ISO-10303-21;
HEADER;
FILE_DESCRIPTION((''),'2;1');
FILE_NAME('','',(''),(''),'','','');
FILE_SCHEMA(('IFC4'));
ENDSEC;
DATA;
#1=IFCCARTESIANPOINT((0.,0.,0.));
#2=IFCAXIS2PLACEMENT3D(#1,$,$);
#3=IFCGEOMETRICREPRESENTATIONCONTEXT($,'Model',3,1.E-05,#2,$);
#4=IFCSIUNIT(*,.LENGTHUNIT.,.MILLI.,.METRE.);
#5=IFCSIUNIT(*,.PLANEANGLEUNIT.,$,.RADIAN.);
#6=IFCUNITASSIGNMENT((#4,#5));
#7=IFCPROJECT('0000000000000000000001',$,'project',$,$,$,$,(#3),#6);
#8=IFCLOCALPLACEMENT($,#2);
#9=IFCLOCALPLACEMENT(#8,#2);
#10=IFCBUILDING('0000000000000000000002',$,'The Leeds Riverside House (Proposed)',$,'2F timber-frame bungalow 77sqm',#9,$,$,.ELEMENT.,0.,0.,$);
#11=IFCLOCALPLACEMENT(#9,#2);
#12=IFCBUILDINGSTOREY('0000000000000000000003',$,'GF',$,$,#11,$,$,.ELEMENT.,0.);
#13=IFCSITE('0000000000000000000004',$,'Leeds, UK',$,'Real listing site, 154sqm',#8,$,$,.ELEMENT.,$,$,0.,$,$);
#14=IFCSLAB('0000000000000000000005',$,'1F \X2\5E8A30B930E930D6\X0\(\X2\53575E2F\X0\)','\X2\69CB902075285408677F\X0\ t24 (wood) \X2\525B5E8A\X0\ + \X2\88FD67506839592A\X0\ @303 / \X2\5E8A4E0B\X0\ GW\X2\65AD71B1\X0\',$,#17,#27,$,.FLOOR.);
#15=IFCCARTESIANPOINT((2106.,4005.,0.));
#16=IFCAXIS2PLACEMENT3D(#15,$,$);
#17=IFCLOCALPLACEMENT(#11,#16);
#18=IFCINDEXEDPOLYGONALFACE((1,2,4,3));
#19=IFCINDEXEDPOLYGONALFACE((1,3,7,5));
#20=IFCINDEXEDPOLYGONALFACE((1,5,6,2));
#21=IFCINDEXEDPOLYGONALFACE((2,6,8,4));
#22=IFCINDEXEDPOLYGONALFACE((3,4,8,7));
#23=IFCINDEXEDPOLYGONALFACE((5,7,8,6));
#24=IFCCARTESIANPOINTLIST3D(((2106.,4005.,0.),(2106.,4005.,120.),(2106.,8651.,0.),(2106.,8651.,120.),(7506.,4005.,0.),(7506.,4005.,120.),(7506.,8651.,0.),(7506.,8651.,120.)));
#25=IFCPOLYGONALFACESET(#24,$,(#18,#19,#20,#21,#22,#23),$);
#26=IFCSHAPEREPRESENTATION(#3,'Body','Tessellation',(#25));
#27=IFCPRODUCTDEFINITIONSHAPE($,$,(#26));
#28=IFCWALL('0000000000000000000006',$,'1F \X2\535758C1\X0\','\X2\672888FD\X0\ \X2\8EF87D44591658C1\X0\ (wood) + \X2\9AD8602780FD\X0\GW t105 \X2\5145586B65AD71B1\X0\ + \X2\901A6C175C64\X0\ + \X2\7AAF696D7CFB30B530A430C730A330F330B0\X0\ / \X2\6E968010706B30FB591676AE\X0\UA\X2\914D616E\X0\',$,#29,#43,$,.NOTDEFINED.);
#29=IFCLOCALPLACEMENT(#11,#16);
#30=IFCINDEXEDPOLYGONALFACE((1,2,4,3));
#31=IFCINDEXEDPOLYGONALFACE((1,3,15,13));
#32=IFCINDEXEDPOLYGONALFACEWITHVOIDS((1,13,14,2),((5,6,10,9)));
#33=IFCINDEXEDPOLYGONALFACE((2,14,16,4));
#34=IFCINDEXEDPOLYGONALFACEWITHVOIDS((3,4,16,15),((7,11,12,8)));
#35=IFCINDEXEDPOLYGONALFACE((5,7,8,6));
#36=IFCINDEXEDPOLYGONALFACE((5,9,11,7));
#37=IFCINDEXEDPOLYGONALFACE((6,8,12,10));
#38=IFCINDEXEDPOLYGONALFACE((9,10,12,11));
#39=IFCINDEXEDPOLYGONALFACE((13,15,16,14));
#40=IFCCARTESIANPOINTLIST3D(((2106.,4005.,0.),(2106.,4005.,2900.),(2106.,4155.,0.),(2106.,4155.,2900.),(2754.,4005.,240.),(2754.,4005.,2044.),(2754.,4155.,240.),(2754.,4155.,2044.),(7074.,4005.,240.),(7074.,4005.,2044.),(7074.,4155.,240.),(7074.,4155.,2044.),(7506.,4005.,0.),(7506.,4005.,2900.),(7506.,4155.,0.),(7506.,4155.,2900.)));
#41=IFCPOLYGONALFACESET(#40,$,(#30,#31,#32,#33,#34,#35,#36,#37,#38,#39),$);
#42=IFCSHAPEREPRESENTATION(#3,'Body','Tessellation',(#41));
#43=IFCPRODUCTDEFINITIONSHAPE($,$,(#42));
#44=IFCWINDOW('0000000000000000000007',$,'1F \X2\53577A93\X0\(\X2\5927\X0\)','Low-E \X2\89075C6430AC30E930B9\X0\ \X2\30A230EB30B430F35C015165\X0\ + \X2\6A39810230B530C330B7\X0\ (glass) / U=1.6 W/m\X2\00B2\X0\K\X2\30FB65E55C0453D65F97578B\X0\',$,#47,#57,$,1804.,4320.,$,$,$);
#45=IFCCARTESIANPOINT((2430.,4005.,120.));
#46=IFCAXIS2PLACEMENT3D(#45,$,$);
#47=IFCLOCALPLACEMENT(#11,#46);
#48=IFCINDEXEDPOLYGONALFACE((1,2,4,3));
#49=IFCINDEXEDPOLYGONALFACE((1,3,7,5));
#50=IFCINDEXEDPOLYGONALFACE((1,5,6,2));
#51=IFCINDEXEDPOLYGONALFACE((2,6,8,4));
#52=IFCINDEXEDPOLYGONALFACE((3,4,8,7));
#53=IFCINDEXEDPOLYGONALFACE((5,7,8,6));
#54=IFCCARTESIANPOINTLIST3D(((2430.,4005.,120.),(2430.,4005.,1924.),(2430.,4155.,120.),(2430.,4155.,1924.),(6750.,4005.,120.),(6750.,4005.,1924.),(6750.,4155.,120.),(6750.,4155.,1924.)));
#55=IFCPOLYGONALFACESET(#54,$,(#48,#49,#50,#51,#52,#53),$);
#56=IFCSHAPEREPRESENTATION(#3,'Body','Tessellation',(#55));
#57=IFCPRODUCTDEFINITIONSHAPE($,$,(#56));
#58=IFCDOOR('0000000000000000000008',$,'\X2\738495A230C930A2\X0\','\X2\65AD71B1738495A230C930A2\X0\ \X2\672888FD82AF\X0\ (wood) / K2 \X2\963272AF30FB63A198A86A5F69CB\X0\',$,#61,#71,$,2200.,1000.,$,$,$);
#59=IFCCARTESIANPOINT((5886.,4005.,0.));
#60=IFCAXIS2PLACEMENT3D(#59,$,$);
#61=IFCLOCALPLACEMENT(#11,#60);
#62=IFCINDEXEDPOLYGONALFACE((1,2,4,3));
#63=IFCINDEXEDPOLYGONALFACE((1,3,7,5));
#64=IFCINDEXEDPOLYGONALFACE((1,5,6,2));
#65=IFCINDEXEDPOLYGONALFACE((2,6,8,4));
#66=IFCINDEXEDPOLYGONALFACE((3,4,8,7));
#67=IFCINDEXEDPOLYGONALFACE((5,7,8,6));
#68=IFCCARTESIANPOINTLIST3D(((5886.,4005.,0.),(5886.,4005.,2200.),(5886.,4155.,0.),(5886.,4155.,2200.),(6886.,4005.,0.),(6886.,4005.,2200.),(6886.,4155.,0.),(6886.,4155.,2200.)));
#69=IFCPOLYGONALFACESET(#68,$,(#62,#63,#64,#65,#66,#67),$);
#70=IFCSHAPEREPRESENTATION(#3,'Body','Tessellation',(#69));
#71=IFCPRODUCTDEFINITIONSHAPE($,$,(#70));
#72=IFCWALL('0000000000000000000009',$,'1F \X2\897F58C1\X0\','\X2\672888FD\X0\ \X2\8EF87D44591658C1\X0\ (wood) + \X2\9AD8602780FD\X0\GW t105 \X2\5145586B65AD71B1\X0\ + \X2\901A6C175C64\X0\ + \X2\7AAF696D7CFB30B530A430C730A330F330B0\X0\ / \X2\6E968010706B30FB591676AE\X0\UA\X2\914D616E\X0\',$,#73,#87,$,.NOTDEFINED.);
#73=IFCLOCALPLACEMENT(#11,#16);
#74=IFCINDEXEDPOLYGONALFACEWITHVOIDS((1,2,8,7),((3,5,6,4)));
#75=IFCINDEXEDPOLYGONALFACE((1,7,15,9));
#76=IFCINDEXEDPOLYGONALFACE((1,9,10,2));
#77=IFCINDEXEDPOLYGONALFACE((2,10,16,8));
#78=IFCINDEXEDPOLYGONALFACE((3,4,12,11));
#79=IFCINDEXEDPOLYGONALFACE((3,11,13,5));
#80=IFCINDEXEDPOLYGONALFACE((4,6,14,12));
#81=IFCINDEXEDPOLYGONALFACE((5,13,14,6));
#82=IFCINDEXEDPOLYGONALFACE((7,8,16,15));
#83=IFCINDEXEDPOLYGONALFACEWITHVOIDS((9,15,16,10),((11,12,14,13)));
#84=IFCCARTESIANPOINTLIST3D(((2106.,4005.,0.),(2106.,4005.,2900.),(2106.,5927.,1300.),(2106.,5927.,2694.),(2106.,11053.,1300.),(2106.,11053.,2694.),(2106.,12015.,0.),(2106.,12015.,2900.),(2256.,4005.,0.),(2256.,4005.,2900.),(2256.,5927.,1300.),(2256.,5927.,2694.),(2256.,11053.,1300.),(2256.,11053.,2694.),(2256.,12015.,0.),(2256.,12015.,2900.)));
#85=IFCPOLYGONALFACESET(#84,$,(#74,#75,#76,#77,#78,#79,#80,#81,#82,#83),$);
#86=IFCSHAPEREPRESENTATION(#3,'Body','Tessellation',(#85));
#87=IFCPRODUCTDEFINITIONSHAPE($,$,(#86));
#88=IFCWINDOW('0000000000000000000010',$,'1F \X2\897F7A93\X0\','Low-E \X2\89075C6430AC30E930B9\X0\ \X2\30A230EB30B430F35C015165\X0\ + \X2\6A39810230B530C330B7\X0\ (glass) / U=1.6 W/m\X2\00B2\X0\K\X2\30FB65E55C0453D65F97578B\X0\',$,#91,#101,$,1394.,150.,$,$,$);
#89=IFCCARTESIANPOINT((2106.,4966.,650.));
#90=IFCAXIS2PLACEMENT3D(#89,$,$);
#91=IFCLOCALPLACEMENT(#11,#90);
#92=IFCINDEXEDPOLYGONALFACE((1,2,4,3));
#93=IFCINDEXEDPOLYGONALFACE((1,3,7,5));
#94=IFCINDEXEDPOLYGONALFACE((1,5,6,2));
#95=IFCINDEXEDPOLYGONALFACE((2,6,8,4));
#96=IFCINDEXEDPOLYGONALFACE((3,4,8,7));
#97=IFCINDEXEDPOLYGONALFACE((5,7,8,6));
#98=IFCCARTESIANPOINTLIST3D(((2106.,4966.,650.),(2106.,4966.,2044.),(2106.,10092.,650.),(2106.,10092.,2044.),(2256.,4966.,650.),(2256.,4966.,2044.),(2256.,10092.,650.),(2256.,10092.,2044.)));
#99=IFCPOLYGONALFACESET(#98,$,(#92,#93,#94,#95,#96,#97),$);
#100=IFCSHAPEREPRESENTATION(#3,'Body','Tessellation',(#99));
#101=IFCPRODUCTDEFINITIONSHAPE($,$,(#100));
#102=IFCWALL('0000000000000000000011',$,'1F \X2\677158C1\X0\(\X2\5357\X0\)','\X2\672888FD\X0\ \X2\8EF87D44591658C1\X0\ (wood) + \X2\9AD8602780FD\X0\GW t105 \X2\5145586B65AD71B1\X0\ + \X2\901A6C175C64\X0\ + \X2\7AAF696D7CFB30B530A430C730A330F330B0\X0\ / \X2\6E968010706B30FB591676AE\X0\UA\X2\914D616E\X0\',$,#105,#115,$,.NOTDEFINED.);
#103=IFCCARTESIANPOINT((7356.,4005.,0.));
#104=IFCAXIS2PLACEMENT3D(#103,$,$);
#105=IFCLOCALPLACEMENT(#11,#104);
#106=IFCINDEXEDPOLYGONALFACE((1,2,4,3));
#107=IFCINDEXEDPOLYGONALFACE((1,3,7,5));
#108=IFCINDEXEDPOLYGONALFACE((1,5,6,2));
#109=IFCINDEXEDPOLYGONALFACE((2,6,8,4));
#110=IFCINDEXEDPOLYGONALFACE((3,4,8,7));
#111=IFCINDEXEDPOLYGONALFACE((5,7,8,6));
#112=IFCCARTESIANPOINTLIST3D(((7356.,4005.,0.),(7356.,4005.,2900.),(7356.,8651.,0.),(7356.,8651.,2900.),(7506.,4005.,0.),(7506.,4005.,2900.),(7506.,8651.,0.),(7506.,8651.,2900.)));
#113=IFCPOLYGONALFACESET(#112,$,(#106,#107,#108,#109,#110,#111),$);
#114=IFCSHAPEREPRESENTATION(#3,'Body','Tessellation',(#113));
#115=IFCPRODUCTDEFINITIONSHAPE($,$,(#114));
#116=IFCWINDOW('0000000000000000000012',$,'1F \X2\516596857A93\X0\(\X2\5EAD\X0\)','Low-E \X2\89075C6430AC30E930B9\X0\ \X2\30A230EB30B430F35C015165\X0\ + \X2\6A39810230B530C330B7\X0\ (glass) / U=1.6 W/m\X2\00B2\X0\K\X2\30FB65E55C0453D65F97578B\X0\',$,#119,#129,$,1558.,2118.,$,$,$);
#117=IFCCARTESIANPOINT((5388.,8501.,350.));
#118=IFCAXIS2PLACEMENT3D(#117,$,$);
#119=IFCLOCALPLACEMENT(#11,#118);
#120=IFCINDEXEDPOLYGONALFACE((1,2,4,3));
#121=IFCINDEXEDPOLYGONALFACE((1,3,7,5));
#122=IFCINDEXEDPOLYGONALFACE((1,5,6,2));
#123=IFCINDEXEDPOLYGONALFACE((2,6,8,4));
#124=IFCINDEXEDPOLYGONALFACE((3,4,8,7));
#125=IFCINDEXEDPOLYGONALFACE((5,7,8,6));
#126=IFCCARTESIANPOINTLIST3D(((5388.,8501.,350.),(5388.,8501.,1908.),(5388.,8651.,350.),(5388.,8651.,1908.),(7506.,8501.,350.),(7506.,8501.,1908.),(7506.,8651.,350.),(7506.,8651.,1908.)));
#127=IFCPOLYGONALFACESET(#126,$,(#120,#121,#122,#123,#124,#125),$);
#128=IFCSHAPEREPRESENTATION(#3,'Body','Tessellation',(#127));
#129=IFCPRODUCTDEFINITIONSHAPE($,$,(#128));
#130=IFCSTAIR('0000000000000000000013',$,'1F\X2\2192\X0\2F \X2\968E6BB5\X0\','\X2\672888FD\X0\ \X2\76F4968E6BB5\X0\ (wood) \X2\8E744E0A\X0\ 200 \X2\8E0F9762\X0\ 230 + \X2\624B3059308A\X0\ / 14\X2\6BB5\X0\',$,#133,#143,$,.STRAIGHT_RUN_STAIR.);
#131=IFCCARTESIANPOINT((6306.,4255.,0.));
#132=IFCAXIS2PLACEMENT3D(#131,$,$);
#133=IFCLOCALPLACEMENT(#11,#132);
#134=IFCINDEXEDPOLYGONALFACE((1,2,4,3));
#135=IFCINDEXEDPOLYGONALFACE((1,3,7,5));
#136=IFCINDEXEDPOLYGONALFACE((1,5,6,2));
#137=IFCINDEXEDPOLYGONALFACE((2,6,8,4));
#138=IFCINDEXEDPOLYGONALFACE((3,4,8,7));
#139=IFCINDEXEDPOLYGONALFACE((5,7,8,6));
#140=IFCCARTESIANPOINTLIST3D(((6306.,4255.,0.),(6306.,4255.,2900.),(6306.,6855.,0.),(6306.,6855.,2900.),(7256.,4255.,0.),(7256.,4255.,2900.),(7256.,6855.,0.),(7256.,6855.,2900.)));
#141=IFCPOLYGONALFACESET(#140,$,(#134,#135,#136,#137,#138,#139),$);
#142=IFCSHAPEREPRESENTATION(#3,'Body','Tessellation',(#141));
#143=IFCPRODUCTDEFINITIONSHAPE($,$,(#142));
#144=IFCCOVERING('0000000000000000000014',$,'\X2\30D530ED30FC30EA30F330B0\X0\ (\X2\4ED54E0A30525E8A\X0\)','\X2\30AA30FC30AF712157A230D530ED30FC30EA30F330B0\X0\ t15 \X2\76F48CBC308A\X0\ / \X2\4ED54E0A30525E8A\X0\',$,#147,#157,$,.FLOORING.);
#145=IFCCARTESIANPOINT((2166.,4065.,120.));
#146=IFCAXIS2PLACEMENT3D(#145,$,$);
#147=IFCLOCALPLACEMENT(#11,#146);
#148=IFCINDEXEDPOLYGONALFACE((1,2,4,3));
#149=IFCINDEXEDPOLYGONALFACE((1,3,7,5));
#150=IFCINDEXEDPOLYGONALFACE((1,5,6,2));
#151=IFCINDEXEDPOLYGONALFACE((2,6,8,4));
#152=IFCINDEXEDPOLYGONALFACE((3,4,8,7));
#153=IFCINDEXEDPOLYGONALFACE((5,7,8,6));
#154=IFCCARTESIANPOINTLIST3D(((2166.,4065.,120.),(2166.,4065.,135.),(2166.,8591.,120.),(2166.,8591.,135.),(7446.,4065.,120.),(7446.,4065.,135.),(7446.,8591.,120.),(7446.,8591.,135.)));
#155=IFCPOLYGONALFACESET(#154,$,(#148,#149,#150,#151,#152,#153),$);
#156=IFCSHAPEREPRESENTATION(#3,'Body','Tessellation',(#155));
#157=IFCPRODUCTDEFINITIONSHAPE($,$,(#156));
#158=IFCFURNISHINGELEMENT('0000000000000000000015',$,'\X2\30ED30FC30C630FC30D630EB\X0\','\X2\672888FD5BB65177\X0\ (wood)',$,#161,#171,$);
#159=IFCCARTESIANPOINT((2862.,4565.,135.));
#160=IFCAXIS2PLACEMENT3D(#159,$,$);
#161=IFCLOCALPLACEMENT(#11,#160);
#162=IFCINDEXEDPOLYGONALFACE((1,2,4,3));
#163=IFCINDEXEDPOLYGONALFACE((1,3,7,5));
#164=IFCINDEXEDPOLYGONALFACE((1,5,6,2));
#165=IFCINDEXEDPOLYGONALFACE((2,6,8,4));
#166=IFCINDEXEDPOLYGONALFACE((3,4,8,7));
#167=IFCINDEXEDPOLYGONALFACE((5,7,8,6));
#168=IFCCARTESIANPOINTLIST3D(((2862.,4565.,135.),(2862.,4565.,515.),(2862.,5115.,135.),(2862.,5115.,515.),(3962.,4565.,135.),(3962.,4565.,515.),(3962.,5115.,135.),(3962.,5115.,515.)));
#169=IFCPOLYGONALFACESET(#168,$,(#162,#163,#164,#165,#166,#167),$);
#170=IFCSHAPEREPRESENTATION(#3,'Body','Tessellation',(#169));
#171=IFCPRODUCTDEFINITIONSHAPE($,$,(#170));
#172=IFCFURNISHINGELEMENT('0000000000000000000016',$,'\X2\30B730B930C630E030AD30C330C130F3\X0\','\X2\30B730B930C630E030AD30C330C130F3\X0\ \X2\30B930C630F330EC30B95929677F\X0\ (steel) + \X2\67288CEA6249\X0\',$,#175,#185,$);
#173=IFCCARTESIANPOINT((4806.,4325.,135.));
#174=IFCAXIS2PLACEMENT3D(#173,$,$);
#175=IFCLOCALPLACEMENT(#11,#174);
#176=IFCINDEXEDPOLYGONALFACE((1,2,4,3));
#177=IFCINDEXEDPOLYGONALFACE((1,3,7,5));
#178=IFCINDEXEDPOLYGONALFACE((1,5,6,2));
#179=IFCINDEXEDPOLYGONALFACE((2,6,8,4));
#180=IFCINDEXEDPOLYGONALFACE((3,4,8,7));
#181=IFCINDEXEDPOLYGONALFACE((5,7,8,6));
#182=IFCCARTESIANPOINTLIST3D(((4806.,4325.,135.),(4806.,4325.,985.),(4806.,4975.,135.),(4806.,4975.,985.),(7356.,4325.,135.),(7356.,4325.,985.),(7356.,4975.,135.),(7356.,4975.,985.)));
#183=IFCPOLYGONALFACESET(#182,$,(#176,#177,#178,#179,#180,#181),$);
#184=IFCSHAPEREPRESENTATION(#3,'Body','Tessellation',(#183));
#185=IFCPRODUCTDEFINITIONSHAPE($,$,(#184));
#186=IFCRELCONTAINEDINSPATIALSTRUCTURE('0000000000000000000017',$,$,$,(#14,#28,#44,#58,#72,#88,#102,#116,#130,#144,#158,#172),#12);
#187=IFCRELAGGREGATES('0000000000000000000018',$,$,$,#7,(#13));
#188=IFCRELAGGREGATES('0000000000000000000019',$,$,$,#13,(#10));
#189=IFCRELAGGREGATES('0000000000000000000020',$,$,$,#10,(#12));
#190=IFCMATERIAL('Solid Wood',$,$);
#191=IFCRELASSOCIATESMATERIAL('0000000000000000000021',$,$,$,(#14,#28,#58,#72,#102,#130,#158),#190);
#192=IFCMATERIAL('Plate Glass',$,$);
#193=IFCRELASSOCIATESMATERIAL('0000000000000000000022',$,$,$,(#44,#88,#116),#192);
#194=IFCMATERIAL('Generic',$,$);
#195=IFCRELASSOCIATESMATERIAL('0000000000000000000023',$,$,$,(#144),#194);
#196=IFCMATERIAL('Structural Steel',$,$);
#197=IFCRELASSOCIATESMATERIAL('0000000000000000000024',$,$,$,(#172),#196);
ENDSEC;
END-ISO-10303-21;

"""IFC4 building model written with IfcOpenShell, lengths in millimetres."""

from ifc_helpers import new_model, si_unit, frame, frame_2d, origin, place, context, project, spatial, rectangle, extrude, material, element, fill, save


model = new_model("IFC4")

# Units and contexts
model_context = context("Model", 3, precision=1e-05, world=origin())
ifc_project = project(units=[si_unit("LENGTHUNIT", "METRE", prefix="MILLI"), si_unit("PLANEANGLEUNIT", "RADIAN")], contexts=[model_context])

# Site, building, storey
site_placement = place(None, origin())
site = spatial("IfcSite", under=ifc_project, at=site_placement, Name="Leeds, UK", ObjectType="Real listing site, 154sqm", CompositionType="ELEMENT", RefElevation=0.0)
building_placement = place(site_placement, origin())
building = spatial("IfcBuilding", under=site, at=building_placement, Name="The Leeds Riverside House (Proposed)", ObjectType="2F timber-frame bungalow 77sqm", CompositionType="ELEMENT", ElevationOfRefHeight=0.0, ElevationOfTerrain=0.0)
storey_placement = place(building_placement, origin())
storey = spatial("IfcBuildingStorey", under=building, at=storey_placement, Name="GF", CompositionType="ELEMENT", Elevation=0.0)

# Slab
ifc_material_1 = material(Name="Solid Wood")
slab_1_placement = place(storey_placement, frame((2106.0, 4005.0, 0.0)))
element("IfcSlab", 1, at=slab_1_placement, inside=storey, material=ifc_material_1, Name="1F 床スラブ(南帯)", Description="構造用合板 t24 (wood) 剛床 + 製材根太 @303 / 床下 GW断熱", PredefinedType="FLOOR", context=model_context, shape_type="SweptSolid", body=[
    extrude(rectangle(XDim=5400.0, YDim=4646.0, at=frame_2d((2700.0, 2323.0))), frame((2106.0, 4005.0, 0.0)), (0.0, 0.0, 1.0), 120.0),
])

# Wall, openings, window, door
wall_1_placement = place(storey_placement, frame((2106.0, 4005.0, 0.0)))
wall_1 = element("IfcWall", 2, at=wall_1_placement, inside=storey, material=ifc_material_1, Name="1F 南壁", Description="木製 軸組外壁 (wood) + 高性能GW t105 充填断熱 + 通気層 + 窯業系サイディング / 準耐火・外皮UA配慮", PredefinedType="NOTDEFINED", context=model_context, shape_type="SweptSolid", body=[
    extrude(rectangle(XDim=5400.0, YDim=150.0, at=frame_2d((2700.0, 75.0))), frame((2106.0, 4005.0, 0.0)), (0.0, 0.0, 1.0), 2900.0),
])
opening_1_placement = place(storey_placement, frame((2430.0, 4005.0, 120.0)))
opening_1 = element("IfcOpeningElement", 3, at=opening_1_placement, cuts=wall_1, PredefinedType="NOTDEFINED", context=model_context, shape_type="SweptSolid", body=[
    extrude(rectangle(XDim=4320.0, YDim=150.0, at=frame_2d((2160.0, 75.0))), frame((2430.0, 4005.0, 120.0)), (0.0, 0.0, 1.0), 1804.0),
])
opening_2_placement = place(storey_placement, frame((5886.0, 4005.0, 0.0)))
opening_2 = element("IfcOpeningElement", 4, at=opening_2_placement, cuts=wall_1, PredefinedType="NOTDEFINED", context=model_context, shape_type="SweptSolid", body=[
    extrude(rectangle(XDim=1000.0, YDim=150.0, at=frame_2d((500.0, 75.0))), frame((5886.0, 4005.0, 0.0)), (0.0, 0.0, 1.0), 2200.0),
])
ifc_material_2 = material(Name="Plate Glass")
window_1_placement = place(storey_placement, frame((2430.0, 4005.0, 120.0)))
window_1 = element("IfcWindow", 5, at=window_1_placement, inside=storey, material=ifc_material_2, Name="1F 南窓(大)", Description="Low-E 複層ガラス アルゴン封入 + 樹脂サッシ (glass) / U=1.6 W/m²K・日射取得型", OverallHeight=1804.0, OverallWidth=4320.0, context=model_context, shape_type="SweptSolid", body=[
    extrude(rectangle(XDim=4320.0, YDim=150.0, at=frame_2d((2160.0, 75.0))), frame((2430.0, 4005.0, 120.0)), (0.0, 0.0, 1.0), 1804.0),
])
fill(opening_1, window_1)
door_1_placement = place(storey_placement, frame((5886.0, 4005.0, 0.0)))
door_1 = element("IfcDoor", 6, at=door_1_placement, inside=storey, material=ifc_material_1, Name="玄関ドア", Description="断熱玄関ドア 木製芯 (wood) / K2 防犯・採風機構", OverallHeight=2200.0, OverallWidth=1000.0, context=model_context, shape_type="SweptSolid", body=[
    extrude(rectangle(XDim=1000.0, YDim=150.0, at=frame_2d((500.0, 75.0))), frame((5886.0, 4005.0, 0.0)), (0.0, 0.0, 1.0), 2200.0),
])
fill(opening_2, door_1)

# Walls, openings, windows
wall_2_placement = place(storey_placement, frame((2106.0, 4005.0, 0.0)))
wall_2 = element("IfcWall", 7, at=wall_2_placement, inside=storey, material=ifc_material_1, Name="1F 西壁", Description="木製 軸組外壁 (wood) + 高性能GW t105 充填断熱 + 通気層 + 窯業系サイディング / 準耐火・外皮UA配慮", PredefinedType="NOTDEFINED", context=model_context, shape_type="SweptSolid", body=[
    extrude(rectangle(XDim=150.0, YDim=8010.0, at=frame_2d((75.0, 4005.0))), frame((2106.0, 4005.0, 0.0)), (0.0, 0.0, 1.0), 2900.0),
])
opening_3_placement = place(storey_placement, frame((2106.0, 4966.0, 650.0)))
opening_3 = element("IfcOpeningElement", 8, at=opening_3_placement, cuts=wall_2, PredefinedType="NOTDEFINED", context=model_context, shape_type="SweptSolid", body=[
    extrude(rectangle(XDim=150.0, YDim=5126.0, at=frame_2d((75.0, 2563.0))), frame((2106.0, 4966.0, 650.0)), (0.0, 0.0, 1.0), 1394.0),
])
window_2_placement = place(storey_placement, frame((2106.0, 4966.0, 650.0)))
window_2 = element("IfcWindow", 9, at=window_2_placement, inside=storey, material=ifc_material_2, Name="1F 西窓", Description="Low-E 複層ガラス アルゴン封入 + 樹脂サッシ (glass) / U=1.6 W/m²K・日射取得型", OverallHeight=1394.0, OverallWidth=150.0, context=model_context, shape_type="SweptSolid", body=[
    extrude(rectangle(XDim=150.0, YDim=5126.0, at=frame_2d((75.0, 2563.0))), frame((2106.0, 4966.0, 650.0)), (0.0, 0.0, 1.0), 1394.0),
])
fill(opening_3, window_2)
wall_3_placement = place(storey_placement, frame((7356.0, 4005.0, 0.0)))
wall_3 = element("IfcWall", 10, at=wall_3_placement, inside=storey, material=ifc_material_1, Name="1F 東壁(南)", Description="木製 軸組外壁 (wood) + 高性能GW t105 充填断熱 + 通気層 + 窯業系サイディング / 準耐火・外皮UA配慮", PredefinedType="NOTDEFINED", context=model_context, shape_type="SweptSolid", body=[
    extrude(rectangle(XDim=150.0, YDim=4646.0, at=frame_2d((75.0, 2323.0))), frame((7356.0, 4005.0, 0.0)), (0.0, 0.0, 1.0), 2900.0),
])
opening_4_placement = place(storey_placement, frame((5388.0, 8501.0, 350.0)))
opening_4 = element("IfcOpeningElement", 11, at=opening_4_placement, cuts=wall_3, PredefinedType="NOTDEFINED", context=model_context, shape_type="SweptSolid", body=[
    extrude(rectangle(XDim=2118.0, YDim=150.0, at=frame_2d((1059.0, 75.0))), frame((5388.0, 8501.0, 350.0)), (0.0, 0.0, 1.0), 1558.0),
])
window_3_placement = place(storey_placement, frame((5388.0, 8501.0, 350.0)))
window_3 = element("IfcWindow", 12, at=window_3_placement, inside=storey, material=ifc_material_2, Name="1F 入隅窓(庭)", Description="Low-E 複層ガラス アルゴン封入 + 樹脂サッシ (glass) / U=1.6 W/m²K・日射取得型", OverallHeight=1558.0, OverallWidth=2118.0, context=model_context, shape_type="SweptSolid", body=[
    extrude(rectangle(XDim=2118.0, YDim=150.0, at=frame_2d((1059.0, 75.0))), frame((5388.0, 8501.0, 350.0)), (0.0, 0.0, 1.0), 1558.0),
])
fill(opening_4, window_3)

# Stair
stair_placement = place(storey_placement, frame((6306.0, 4255.0, 0.0)))
element("IfcStair", 13, at=stair_placement, inside=storey, material=ifc_material_1, Name="1F→2F 階段", Description="木製 直階段 (wood) 蹴上 200 踏面 230 + 手すり / 14段", PredefinedType="STRAIGHT_RUN_STAIR", context=model_context, shape_type="SweptSolid", body=[
    extrude(rectangle(XDim=950.0, YDim=2600.0, at=frame_2d((475.0, 1300.0))), frame((6306.0, 4255.0, 0.0)), (0.0, 0.0, 1.0), 2900.0),
])

# Covering
ifc_material_3 = material(Name="Generic")
covering_placement = place(storey_placement, frame((2166.0, 4065.0, 120.0)))
element("IfcCovering", 14, at=covering_placement, inside=storey, material=ifc_material_3, Name="フローリング (仕上げ床)", Description="オーク無垢フローリング t15 直貼り / 仕上げ床", PredefinedType="FLOORING", context=model_context, shape_type="SweptSolid", body=[
    extrude(rectangle(XDim=5280.0, YDim=4526.0, at=frame_2d((2640.0, 2263.0))), frame((2166.0, 4065.0, 120.0)), (0.0, 0.0, 1.0), 15.0),
])

# Furnishing elements
furnishing_1_placement = place(storey_placement, frame((2862.0, 4565.0, 135.0)))
element("IfcFurnishingElement", 15, at=furnishing_1_placement, inside=storey, material=ifc_material_1, Name="ローテーブル", Description="木製家具 (wood)", context=model_context, shape_type="SweptSolid", body=[
    extrude(rectangle(XDim=1100.0, YDim=550.0, at=frame_2d((550.0, 275.0))), frame((2862.0, 4565.0, 135.0)), (0.0, 0.0, 1.0), 380.0),
])
ifc_material_4 = material(Name="Structural Steel")
furnishing_2_placement = place(storey_placement, frame((4806.0, 4325.0, 135.0)))
element("IfcFurnishingElement", 16, at=furnishing_2_placement, inside=storey, material=ifc_material_4, Name="システムキッチン", Description="システムキッチン ステンレス天板 (steel) + 木質扉", context=model_context, shape_type="SweptSolid", body=[
    extrude(rectangle(XDim=2550.0, YDim=650.0, at=frame_2d((1275.0, 325.0))), frame((4806.0, 4325.0, 135.0)), (0.0, 0.0, 1.0), 850.0),
])

save(model, "model.ifc")
